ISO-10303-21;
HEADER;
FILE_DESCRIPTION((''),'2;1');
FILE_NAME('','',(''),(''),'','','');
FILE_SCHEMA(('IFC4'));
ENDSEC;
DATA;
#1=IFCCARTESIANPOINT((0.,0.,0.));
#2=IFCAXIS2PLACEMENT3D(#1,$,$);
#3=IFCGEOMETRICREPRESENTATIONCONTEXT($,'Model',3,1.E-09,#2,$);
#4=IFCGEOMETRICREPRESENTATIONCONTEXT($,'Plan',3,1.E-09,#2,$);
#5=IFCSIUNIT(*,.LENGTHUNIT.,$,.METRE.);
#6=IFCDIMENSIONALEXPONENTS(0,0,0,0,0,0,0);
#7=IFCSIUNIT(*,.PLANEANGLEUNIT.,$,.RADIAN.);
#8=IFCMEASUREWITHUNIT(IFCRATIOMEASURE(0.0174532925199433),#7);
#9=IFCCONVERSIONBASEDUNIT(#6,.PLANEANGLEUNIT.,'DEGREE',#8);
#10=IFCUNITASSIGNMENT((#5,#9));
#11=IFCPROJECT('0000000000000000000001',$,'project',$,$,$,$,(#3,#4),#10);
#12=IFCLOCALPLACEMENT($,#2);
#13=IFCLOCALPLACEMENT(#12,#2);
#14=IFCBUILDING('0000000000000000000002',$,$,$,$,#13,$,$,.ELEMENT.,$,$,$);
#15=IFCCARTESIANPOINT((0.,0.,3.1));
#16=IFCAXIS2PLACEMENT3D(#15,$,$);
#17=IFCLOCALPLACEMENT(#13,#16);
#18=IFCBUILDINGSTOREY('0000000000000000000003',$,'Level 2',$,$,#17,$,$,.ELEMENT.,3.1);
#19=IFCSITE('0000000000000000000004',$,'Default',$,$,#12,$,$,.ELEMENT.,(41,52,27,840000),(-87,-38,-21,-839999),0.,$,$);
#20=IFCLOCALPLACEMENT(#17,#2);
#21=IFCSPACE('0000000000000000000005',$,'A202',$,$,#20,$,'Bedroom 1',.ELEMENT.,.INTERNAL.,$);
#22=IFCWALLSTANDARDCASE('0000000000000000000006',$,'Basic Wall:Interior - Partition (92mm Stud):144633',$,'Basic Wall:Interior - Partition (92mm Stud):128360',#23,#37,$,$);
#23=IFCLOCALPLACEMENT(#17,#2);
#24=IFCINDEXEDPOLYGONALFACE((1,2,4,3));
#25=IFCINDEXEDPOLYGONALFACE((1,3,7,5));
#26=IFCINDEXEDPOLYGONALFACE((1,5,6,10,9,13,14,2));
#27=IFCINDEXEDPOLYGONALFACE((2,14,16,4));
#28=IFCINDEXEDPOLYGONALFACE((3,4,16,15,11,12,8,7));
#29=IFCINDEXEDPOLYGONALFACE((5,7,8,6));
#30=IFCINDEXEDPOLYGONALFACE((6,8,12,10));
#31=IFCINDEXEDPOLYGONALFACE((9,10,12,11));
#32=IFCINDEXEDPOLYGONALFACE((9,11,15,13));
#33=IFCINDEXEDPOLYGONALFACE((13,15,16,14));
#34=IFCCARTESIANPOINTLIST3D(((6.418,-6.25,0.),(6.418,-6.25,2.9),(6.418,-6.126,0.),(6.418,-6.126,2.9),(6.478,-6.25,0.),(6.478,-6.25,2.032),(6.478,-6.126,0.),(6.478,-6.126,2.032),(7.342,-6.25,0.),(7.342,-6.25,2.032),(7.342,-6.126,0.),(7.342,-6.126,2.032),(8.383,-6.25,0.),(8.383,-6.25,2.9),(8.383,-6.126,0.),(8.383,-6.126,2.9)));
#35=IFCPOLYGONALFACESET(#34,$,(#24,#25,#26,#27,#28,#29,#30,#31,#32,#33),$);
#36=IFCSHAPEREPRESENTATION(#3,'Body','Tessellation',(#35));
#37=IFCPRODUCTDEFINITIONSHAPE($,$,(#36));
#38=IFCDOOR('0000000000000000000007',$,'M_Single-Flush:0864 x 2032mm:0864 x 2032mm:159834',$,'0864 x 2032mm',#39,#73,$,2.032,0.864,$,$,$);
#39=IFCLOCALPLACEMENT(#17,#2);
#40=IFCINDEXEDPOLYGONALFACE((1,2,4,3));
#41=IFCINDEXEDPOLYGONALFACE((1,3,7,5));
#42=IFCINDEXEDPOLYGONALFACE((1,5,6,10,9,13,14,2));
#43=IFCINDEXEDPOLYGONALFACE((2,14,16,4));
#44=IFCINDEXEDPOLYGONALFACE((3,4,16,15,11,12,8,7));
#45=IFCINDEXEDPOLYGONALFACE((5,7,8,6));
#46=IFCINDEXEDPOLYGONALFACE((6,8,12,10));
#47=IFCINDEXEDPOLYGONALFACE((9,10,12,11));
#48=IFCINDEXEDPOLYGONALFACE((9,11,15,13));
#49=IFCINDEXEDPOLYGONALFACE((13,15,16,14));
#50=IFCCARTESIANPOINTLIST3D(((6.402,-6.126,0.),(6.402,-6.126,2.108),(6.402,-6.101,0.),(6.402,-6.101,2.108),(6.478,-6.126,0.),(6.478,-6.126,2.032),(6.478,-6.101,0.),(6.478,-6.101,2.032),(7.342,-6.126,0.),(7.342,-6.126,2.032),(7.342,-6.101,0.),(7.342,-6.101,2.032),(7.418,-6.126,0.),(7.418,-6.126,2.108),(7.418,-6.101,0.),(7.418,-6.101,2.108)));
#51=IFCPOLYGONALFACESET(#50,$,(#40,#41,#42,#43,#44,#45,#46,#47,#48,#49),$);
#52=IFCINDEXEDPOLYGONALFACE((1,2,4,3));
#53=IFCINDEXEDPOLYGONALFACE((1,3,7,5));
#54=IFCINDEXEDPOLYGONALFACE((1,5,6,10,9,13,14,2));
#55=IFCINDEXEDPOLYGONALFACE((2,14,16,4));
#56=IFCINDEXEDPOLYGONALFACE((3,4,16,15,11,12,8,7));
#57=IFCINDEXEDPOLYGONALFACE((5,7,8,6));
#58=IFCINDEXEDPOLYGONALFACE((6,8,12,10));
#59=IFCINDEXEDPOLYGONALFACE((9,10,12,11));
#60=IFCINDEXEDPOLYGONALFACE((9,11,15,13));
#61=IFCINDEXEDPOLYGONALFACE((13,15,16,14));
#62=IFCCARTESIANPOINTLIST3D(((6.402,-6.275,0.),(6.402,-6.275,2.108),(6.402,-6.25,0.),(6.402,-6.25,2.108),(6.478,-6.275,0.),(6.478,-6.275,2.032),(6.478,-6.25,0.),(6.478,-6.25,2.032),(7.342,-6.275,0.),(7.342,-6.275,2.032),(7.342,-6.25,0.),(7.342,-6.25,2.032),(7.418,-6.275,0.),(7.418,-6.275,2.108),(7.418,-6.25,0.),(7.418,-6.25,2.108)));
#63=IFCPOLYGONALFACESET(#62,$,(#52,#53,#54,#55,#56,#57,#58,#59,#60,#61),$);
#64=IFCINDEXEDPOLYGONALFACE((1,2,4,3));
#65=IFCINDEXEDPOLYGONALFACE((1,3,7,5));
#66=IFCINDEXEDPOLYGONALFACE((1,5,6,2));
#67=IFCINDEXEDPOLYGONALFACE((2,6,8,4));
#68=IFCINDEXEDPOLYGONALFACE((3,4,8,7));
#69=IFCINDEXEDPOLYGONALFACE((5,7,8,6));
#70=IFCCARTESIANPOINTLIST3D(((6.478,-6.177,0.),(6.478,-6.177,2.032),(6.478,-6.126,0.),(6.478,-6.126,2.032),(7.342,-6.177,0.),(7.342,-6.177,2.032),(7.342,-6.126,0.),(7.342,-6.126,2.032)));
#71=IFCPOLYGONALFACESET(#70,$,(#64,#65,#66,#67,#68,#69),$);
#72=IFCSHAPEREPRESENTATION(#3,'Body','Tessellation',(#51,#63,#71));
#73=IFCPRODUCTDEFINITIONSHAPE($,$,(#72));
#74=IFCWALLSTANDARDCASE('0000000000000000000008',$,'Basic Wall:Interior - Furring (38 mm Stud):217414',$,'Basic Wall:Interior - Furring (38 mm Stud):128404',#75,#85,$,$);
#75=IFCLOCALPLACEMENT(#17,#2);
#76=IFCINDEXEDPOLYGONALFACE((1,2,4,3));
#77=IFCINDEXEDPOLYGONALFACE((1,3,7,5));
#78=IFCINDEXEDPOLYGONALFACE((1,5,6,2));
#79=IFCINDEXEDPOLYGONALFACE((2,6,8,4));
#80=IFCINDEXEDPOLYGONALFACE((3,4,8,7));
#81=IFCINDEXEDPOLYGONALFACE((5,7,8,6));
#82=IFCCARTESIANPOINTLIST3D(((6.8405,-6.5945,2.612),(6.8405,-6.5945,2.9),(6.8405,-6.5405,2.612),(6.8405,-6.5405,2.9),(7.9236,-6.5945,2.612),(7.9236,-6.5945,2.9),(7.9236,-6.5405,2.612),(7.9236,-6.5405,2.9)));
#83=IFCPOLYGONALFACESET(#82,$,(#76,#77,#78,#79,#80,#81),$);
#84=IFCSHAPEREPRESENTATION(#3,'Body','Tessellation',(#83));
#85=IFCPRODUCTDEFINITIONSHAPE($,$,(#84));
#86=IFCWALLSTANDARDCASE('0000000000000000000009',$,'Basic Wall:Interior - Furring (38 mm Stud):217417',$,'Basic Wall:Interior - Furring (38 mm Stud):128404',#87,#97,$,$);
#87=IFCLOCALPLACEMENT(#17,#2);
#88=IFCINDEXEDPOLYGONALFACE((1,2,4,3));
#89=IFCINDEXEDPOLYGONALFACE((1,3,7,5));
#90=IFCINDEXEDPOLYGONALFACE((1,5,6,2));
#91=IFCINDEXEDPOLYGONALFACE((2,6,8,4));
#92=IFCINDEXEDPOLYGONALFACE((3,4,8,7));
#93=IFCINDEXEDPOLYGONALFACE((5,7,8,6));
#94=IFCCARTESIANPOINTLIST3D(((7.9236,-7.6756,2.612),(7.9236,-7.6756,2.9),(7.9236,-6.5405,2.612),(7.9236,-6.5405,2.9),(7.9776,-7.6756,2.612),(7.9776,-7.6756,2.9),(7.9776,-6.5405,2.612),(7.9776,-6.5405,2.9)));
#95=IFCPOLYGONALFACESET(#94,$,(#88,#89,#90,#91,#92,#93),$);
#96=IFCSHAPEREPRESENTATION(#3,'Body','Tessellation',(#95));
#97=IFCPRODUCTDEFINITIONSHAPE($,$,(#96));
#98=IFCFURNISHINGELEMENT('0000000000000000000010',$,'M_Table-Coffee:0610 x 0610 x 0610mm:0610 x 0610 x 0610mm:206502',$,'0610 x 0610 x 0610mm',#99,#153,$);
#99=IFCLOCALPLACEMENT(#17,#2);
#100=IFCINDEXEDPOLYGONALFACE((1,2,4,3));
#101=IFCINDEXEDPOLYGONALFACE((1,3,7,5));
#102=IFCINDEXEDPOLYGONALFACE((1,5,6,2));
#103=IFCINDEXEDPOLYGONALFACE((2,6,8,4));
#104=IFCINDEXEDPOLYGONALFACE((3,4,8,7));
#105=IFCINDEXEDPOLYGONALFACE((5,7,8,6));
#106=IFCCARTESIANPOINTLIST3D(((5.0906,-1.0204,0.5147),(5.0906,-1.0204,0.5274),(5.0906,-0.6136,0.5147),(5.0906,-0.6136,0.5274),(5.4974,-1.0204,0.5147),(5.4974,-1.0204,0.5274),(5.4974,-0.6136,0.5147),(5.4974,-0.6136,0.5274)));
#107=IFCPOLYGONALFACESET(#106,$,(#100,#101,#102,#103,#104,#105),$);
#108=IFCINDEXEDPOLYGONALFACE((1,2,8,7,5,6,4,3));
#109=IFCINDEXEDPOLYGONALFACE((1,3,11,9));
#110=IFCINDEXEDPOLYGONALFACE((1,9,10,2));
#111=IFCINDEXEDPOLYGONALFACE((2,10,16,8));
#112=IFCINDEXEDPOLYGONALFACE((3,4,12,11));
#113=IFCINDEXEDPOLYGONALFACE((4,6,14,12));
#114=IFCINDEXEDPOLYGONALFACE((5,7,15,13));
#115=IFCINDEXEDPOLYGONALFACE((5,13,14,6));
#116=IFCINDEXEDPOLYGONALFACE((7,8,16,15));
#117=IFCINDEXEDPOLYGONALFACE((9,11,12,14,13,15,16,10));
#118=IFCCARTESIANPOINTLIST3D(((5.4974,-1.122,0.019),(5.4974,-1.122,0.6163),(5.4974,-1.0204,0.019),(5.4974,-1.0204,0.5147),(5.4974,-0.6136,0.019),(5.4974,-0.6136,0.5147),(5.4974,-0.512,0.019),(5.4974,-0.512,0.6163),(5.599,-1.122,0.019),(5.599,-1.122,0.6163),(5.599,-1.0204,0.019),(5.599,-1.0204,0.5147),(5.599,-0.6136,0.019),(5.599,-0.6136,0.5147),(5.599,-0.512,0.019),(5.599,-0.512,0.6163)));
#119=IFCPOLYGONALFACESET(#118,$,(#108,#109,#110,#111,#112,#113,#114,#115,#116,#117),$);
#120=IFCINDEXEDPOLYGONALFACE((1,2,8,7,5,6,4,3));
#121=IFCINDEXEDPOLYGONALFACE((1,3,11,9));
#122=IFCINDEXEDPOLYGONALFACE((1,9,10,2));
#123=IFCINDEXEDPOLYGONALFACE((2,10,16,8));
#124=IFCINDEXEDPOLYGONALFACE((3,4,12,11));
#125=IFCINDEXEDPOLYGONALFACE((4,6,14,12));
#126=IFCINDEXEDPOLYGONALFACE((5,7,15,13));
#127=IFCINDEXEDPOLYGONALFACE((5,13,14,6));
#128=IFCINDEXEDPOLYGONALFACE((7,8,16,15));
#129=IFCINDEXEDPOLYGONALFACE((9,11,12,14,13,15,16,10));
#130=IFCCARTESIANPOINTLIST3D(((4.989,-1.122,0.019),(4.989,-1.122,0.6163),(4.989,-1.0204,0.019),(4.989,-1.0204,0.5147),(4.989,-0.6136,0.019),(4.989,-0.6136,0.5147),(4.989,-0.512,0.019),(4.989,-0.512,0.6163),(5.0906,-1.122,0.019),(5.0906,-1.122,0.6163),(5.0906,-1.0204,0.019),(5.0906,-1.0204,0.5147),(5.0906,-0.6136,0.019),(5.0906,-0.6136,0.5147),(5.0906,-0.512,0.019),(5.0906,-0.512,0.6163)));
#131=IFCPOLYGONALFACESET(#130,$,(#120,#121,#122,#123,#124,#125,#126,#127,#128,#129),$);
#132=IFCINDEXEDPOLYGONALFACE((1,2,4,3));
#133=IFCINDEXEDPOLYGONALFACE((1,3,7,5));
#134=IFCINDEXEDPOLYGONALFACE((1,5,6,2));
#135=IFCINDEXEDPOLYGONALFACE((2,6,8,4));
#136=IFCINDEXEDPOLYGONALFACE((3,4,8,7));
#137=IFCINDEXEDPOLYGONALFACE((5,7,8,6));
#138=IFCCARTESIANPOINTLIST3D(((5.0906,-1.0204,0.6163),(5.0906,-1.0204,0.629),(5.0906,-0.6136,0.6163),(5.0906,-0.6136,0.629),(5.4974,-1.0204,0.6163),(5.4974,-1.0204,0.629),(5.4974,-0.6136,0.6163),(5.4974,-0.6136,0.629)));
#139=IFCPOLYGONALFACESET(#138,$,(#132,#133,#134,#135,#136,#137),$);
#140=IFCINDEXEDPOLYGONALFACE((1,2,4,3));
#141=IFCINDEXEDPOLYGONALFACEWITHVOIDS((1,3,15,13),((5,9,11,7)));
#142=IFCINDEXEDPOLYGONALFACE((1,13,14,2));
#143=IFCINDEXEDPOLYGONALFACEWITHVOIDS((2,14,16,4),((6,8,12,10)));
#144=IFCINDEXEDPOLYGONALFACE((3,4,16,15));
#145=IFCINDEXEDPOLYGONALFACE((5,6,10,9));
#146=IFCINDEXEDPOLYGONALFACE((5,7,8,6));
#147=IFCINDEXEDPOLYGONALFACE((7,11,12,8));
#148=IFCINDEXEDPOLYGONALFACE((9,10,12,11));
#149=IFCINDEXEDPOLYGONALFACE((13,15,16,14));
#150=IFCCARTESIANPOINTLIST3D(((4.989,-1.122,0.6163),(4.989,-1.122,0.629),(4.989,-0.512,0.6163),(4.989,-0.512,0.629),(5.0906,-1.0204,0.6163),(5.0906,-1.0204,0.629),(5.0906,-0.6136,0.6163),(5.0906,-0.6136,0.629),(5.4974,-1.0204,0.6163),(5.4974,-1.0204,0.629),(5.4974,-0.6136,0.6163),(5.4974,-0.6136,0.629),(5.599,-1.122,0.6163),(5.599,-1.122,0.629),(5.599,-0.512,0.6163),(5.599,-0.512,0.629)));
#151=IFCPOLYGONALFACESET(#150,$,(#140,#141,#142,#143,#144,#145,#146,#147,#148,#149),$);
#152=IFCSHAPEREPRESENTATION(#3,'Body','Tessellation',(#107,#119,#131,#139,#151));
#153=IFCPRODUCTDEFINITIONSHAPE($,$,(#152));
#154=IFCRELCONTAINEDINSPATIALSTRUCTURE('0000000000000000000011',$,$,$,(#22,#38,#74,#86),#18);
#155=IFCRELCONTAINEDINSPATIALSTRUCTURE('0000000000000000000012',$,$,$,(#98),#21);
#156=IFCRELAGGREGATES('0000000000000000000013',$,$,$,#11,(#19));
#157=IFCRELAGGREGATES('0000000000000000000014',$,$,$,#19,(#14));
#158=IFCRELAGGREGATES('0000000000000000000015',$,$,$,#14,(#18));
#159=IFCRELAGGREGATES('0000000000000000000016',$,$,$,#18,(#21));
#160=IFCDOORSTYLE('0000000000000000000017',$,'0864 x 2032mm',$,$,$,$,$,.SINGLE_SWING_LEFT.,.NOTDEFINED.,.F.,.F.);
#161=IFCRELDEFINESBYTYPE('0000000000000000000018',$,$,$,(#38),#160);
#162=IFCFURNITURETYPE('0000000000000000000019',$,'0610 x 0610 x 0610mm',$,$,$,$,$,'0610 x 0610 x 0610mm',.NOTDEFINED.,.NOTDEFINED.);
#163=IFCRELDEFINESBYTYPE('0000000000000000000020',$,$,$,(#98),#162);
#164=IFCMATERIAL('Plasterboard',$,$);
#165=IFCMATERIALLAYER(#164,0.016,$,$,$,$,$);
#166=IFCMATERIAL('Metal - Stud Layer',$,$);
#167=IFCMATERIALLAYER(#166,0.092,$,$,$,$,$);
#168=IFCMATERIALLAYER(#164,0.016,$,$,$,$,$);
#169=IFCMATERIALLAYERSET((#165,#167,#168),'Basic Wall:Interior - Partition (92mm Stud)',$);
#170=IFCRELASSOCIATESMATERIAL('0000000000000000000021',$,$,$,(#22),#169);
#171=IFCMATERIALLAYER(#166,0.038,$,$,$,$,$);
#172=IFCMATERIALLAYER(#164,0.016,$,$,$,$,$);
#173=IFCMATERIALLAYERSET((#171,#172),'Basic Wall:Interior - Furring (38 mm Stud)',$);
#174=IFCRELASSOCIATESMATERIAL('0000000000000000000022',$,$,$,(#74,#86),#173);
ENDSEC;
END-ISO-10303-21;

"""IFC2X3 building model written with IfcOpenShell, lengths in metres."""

from ifc_helpers import new_model, entity, si_unit, converted_unit, frame, frame_2d, origin, origin_2d_with_axis, place, context, project, spatial, polyline, rectangle, outline, extrude, source, transform, mapped, material, layer, layer_set, layer_usage, type_object, type_shapes, element, fill, save


model = new_model("IFC2X3")

# Units and contexts
model_context = context("Model", 3, precision=1e-09, world=origin())
plan_context = context("Plan", 3, precision=1e-09, world=origin())
ifc_project = project(units=[si_unit("LENGTHUNIT", "METRE"), converted_unit("PLANEANGLEUNIT", "DEGREE", entity("IfcRatioMeasure", 0.0174532925199433), si_unit("PLANEANGLEUNIT", "RADIAN"), dimensions=[0, 0, 0, 0, 0, 0, 0])], contexts=[model_context, plan_context])

# Site, building, storey
site_placement = place(None, origin())
site = spatial("IfcSite", under=ifc_project, at=site_placement, Name="Default", CompositionType="ELEMENT", RefLatitude=(41, 52, 27, 840000), RefLongitude=(-87, -38, -21, -839999), RefElevation=0.0)
building_placement = place(site_placement, origin())
building = spatial("IfcBuilding", under=site, at=building_placement, CompositionType="ELEMENT")
storey_placement = place(building_placement, frame((0.0, 0.0, 3.1)))
storey = spatial("IfcBuildingStorey", under=building, at=storey_placement, Name="Level 2", CompositionType="ELEMENT", Elevation=3.1)

# Shared definitions
ifc_material_1 = material(Name="Plasterboard")
ifc_layer_1 = layer(ifc_material_1, 0.016)
ifc_material_2 = material(Name="Metal - Stud Layer")
ifc_layer_2 = layer(ifc_material_2, 0.092)
ifc_layer_3 = layer(ifc_material_1, 0.016)
ifc_layer_set_1 = layer_set([ifc_layer_1, ifc_layer_2, ifc_layer_3], Name="Basic Wall:Interior - Partition (92mm Stud)")
ifc_layer_usage_1 = layer_usage(ifc_layer_set_1, "AXIS2", "NEGATIVE", 0.062)

# Wall, opening, door
wall_1_placement = place(storey_placement, frame((6.418, -6.188, 0.0)))
wall_1 = element("IfcWallStandardCase", 1, at=wall_1_placement, inside=storey, material=ifc_layer_usage_1, Name="Basic Wall:Interior - Partition (92mm Stud):144633", ObjectType="Basic Wall:Interior - Partition (92mm Stud):128360", context=model_context, shape_type="SweptSolid", body=[
    extrude(rectangle(XDim=1.965, YDim=0.124, at=frame_2d((0.9825, 0.0), x_axis=(-1.0, 0.0))), origin(), (0.0, 0.0, 1.0), 2.9),
])
opening_1_placement = place(wall_1_placement, frame((0.06, -0.062, 0.0)))
opening_1 = element("IfcOpeningElement", 2, at=opening_1_placement, cuts=wall_1, ObjectType="Opening", context=model_context, shape_type="SweptSolid", body=[
    extrude(rectangle(XDim=0.864, YDim=2.032, at=frame_2d((1.016, 0.432), x_axis=(0.0, -1.0))), frame((0.0, 0.0, 0.0), z_axis=(0.0, 1.0, 0.0), x_axis=(0.0, 0.0, 1.0)), (0.0, 0.0, 1.0), 0.124),
])
door_style_1 = type_object("IfcDoorStyle", Name="0864 x 2032mm", ConstructionType="NOTDEFINED", OperationType="SINGLE_SWING_LEFT", ParameterTakesPrecedence=False, Sizeable=False)
shared_shape_1 = source(origin(), model_context, "Body", "SweptSolid", [
    extrude(outline(polyline([(-0.508, -1.073), (0.508, -1.073), (0.508, 1.035), (0.432, 1.035), (0.432, -0.997), (-0.432, -0.997), (-0.432, 1.035), (-0.508, 1.035), (-0.508, -1.073)])), frame((0.432, 0.149, 1.035), z_axis=(0.0, -1.0, 0.0), x_axis=(-1.0, 0.0, 0.0)), (0.0, 0.0, 1.0), 0.025),
    extrude(outline(polyline([(-1.073, -0.508), (1.035, -0.508), (1.035, -0.432), (-0.997, -0.432), (-0.997, 0.432), (1.035, 0.432), (1.035, 0.508), (-1.073, 0.508), (-1.073, -0.508)])), frame((0.432, 0.0, 1.035), z_axis=(0.0, -1.0, 0.0), x_axis=(0.0, 0.0, -1.0)), (0.0, 0.0, 1.0), 0.025),
    extrude(rectangle(XDim=0.864, YDim=0.051, at=origin_2d_with_axis()), frame((0.432, 0.0985, 0.0)), (0.0, 0.0, 1.0), 2.032),
])
type_shapes(door_style_1, [shared_shape_1])
door_1_placement = place(opening_1_placement, origin())
door_1 = element("IfcDoor", 3, at=door_1_placement, inside=storey, type_object=door_style_1, Name="M_Single-Flush:0864 x 2032mm:0864 x 2032mm:159834", ObjectType="0864 x 2032mm", OverallHeight=2.032, OverallWidth=0.864, context=model_context, shape_type="MappedRepresentation", body=[
    mapped(shared_shape_1, transform((0.0, 0.0, 0.0), scale=1.0)),
])
fill(opening_1, door_1)

# Walls
ifc_layer_4 = layer(ifc_material_2, 0.038)
ifc_layer_5 = layer(ifc_material_1, 0.016)
ifc_layer_set_2 = layer_set([ifc_layer_4, ifc_layer_5], Name="Basic Wall:Interior - Furring (38 mm Stud)")
ifc_layer_usage_2 = layer_usage(ifc_layer_set_2, "AXIS2", "NEGATIVE", 0.027)
wall_2_placement = place(storey_placement, frame((6.8405, -6.5675, 2.612)))
element("IfcWallStandardCase", 4, at=wall_2_placement, inside=storey, material=ifc_layer_usage_2, Name="Basic Wall:Interior - Furring (38 mm Stud):217414", ObjectType="Basic Wall:Interior - Furring (38 mm Stud):128404", context=model_context, shape_type="SweptSolid", body=[
    extrude(rectangle(XDim=1.0831, YDim=0.054, at=frame_2d((0.5415, 0.0), x_axis=(-1.0, 0.0))), origin(), (0.0, 0.0, 1.0), 0.288),
])
wall_3_placement = place(storey_placement, frame((7.9506, -6.5405, 2.612), z_axis=(0.0, 0.0, 1.0), x_axis=(0.0, -1.0, 0.0)))
element("IfcWallStandardCase", 5, at=wall_3_placement, inside=storey, material=ifc_layer_usage_2, Name="Basic Wall:Interior - Furring (38 mm Stud):217417", ObjectType="Basic Wall:Interior - Furring (38 mm Stud):128404", context=model_context, shape_type="SweptSolid", body=[
    extrude(rectangle(XDim=1.1351, YDim=0.054, at=frame_2d((0.5675, 0.0), x_axis=(-1.0, 0.0))), origin(), (0.0, 0.0, 1.0), 0.288),
])

# Shared definitions
space_1_placement = place(storey_placement, origin())
space_1 = spatial("IfcSpace", under=storey, at=space_1_placement, Name="A202", LongName="Bedroom 1", CompositionType="ELEMENT", InteriorOrExteriorSpace="INTERNAL")

# Furnishing element
furniture_type = type_object("IfcFurnitureType", Name="0610 x 0610 x 0610mm", ElementType="0610 x 0610 x 0610mm", AssemblyPlace="NOTDEFINED")
shared_shape_2 = source(origin(), model_context, "Body", "SweptSolid", [
    extrude(rectangle(XDim=0.4068, YDim=0.4068, at=origin_2d_with_axis()), frame((0.0183, 0.0952, 0.4957), z_axis=(0.0, 0.0, 1.0), x_axis=(-1.0, 0.0, 0.0)), (0.0, 0.0, 1.0), 0.0127),
    extrude(outline(polyline([(-0.2732, -0.305), (0.324, -0.305), (0.324, 0.305), (-0.2732, 0.305), (-0.2732, 0.2034), (0.2225, 0.2034), (0.2225, -0.2034), (-0.2732, -0.2034), (-0.2732, -0.305)])), frame((0.2217, 0.0952, 0.2732), z_axis=(1.0, 0.0, 0.0), x_axis=(0.0, 0.0, 1.0)), (0.0, 0.0, 1.0), 0.1016),
    extrude(outline(polyline([(-0.305, -0.3241), (0.305, -0.3241), (0.305, 0.2733), (0.2034, 0.2733), (0.2034, -0.2224), (-0.2034, -0.2224), (-0.2034, 0.2733), (-0.305, 0.2733), (-0.305, -0.3241)])), frame((-0.2867, 0.0952, 0.2733), z_axis=(1.0, 0.0, 0.0), x_axis=(0.0, -1.0, 0.0)), (0.0, 0.0, 1.0), 0.1016),
    extrude(rectangle(XDim=0.4068, YDim=0.4068, at=origin_2d_with_axis()), frame((0.0183, 0.0952, 0.5973), z_axis=(0.0, 0.0, 1.0), x_axis=(-1.0, 0.0, 0.0)), (0.0, 0.0, 1.0), 0.0127),
    extrude(outline(polyline([(-0.305, -0.305), (0.305, -0.305), (0.305, 0.305), (-0.305, 0.305), (-0.305, -0.305)]), holes=[polyline([(-0.2034, -0.2034), (-0.2034, 0.2034), (0.2034, 0.2034), (0.2034, -0.2034), (-0.2034, -0.2034)])]), frame((0.0183, 0.0952, 0.5973), z_axis=(0.0, 0.0, 1.0), x_axis=(-1.0, 0.0, 0.0)), (0.0, 0.0, 1.0), 0.0127),
])
type_shapes(furniture_type, [shared_shape_2])
furnishing_1_placement = place(space_1_placement, frame((5.2757, -0.9122, 0.019)))
element("IfcFurnishingElement", 6, at=furnishing_1_placement, inside=space_1, type_object=furniture_type, Name="M_Table-Coffee:0610 x 0610 x 0610mm:0610 x 0610 x 0610mm:206502", ObjectType="0610 x 0610 x 0610mm", context=model_context, shape_type="MappedRepresentation", body=[
    mapped(shared_shape_2, transform((0.0, 0.0, 0.0), scale=1.0)),
])

save(model, "model.ifc")
